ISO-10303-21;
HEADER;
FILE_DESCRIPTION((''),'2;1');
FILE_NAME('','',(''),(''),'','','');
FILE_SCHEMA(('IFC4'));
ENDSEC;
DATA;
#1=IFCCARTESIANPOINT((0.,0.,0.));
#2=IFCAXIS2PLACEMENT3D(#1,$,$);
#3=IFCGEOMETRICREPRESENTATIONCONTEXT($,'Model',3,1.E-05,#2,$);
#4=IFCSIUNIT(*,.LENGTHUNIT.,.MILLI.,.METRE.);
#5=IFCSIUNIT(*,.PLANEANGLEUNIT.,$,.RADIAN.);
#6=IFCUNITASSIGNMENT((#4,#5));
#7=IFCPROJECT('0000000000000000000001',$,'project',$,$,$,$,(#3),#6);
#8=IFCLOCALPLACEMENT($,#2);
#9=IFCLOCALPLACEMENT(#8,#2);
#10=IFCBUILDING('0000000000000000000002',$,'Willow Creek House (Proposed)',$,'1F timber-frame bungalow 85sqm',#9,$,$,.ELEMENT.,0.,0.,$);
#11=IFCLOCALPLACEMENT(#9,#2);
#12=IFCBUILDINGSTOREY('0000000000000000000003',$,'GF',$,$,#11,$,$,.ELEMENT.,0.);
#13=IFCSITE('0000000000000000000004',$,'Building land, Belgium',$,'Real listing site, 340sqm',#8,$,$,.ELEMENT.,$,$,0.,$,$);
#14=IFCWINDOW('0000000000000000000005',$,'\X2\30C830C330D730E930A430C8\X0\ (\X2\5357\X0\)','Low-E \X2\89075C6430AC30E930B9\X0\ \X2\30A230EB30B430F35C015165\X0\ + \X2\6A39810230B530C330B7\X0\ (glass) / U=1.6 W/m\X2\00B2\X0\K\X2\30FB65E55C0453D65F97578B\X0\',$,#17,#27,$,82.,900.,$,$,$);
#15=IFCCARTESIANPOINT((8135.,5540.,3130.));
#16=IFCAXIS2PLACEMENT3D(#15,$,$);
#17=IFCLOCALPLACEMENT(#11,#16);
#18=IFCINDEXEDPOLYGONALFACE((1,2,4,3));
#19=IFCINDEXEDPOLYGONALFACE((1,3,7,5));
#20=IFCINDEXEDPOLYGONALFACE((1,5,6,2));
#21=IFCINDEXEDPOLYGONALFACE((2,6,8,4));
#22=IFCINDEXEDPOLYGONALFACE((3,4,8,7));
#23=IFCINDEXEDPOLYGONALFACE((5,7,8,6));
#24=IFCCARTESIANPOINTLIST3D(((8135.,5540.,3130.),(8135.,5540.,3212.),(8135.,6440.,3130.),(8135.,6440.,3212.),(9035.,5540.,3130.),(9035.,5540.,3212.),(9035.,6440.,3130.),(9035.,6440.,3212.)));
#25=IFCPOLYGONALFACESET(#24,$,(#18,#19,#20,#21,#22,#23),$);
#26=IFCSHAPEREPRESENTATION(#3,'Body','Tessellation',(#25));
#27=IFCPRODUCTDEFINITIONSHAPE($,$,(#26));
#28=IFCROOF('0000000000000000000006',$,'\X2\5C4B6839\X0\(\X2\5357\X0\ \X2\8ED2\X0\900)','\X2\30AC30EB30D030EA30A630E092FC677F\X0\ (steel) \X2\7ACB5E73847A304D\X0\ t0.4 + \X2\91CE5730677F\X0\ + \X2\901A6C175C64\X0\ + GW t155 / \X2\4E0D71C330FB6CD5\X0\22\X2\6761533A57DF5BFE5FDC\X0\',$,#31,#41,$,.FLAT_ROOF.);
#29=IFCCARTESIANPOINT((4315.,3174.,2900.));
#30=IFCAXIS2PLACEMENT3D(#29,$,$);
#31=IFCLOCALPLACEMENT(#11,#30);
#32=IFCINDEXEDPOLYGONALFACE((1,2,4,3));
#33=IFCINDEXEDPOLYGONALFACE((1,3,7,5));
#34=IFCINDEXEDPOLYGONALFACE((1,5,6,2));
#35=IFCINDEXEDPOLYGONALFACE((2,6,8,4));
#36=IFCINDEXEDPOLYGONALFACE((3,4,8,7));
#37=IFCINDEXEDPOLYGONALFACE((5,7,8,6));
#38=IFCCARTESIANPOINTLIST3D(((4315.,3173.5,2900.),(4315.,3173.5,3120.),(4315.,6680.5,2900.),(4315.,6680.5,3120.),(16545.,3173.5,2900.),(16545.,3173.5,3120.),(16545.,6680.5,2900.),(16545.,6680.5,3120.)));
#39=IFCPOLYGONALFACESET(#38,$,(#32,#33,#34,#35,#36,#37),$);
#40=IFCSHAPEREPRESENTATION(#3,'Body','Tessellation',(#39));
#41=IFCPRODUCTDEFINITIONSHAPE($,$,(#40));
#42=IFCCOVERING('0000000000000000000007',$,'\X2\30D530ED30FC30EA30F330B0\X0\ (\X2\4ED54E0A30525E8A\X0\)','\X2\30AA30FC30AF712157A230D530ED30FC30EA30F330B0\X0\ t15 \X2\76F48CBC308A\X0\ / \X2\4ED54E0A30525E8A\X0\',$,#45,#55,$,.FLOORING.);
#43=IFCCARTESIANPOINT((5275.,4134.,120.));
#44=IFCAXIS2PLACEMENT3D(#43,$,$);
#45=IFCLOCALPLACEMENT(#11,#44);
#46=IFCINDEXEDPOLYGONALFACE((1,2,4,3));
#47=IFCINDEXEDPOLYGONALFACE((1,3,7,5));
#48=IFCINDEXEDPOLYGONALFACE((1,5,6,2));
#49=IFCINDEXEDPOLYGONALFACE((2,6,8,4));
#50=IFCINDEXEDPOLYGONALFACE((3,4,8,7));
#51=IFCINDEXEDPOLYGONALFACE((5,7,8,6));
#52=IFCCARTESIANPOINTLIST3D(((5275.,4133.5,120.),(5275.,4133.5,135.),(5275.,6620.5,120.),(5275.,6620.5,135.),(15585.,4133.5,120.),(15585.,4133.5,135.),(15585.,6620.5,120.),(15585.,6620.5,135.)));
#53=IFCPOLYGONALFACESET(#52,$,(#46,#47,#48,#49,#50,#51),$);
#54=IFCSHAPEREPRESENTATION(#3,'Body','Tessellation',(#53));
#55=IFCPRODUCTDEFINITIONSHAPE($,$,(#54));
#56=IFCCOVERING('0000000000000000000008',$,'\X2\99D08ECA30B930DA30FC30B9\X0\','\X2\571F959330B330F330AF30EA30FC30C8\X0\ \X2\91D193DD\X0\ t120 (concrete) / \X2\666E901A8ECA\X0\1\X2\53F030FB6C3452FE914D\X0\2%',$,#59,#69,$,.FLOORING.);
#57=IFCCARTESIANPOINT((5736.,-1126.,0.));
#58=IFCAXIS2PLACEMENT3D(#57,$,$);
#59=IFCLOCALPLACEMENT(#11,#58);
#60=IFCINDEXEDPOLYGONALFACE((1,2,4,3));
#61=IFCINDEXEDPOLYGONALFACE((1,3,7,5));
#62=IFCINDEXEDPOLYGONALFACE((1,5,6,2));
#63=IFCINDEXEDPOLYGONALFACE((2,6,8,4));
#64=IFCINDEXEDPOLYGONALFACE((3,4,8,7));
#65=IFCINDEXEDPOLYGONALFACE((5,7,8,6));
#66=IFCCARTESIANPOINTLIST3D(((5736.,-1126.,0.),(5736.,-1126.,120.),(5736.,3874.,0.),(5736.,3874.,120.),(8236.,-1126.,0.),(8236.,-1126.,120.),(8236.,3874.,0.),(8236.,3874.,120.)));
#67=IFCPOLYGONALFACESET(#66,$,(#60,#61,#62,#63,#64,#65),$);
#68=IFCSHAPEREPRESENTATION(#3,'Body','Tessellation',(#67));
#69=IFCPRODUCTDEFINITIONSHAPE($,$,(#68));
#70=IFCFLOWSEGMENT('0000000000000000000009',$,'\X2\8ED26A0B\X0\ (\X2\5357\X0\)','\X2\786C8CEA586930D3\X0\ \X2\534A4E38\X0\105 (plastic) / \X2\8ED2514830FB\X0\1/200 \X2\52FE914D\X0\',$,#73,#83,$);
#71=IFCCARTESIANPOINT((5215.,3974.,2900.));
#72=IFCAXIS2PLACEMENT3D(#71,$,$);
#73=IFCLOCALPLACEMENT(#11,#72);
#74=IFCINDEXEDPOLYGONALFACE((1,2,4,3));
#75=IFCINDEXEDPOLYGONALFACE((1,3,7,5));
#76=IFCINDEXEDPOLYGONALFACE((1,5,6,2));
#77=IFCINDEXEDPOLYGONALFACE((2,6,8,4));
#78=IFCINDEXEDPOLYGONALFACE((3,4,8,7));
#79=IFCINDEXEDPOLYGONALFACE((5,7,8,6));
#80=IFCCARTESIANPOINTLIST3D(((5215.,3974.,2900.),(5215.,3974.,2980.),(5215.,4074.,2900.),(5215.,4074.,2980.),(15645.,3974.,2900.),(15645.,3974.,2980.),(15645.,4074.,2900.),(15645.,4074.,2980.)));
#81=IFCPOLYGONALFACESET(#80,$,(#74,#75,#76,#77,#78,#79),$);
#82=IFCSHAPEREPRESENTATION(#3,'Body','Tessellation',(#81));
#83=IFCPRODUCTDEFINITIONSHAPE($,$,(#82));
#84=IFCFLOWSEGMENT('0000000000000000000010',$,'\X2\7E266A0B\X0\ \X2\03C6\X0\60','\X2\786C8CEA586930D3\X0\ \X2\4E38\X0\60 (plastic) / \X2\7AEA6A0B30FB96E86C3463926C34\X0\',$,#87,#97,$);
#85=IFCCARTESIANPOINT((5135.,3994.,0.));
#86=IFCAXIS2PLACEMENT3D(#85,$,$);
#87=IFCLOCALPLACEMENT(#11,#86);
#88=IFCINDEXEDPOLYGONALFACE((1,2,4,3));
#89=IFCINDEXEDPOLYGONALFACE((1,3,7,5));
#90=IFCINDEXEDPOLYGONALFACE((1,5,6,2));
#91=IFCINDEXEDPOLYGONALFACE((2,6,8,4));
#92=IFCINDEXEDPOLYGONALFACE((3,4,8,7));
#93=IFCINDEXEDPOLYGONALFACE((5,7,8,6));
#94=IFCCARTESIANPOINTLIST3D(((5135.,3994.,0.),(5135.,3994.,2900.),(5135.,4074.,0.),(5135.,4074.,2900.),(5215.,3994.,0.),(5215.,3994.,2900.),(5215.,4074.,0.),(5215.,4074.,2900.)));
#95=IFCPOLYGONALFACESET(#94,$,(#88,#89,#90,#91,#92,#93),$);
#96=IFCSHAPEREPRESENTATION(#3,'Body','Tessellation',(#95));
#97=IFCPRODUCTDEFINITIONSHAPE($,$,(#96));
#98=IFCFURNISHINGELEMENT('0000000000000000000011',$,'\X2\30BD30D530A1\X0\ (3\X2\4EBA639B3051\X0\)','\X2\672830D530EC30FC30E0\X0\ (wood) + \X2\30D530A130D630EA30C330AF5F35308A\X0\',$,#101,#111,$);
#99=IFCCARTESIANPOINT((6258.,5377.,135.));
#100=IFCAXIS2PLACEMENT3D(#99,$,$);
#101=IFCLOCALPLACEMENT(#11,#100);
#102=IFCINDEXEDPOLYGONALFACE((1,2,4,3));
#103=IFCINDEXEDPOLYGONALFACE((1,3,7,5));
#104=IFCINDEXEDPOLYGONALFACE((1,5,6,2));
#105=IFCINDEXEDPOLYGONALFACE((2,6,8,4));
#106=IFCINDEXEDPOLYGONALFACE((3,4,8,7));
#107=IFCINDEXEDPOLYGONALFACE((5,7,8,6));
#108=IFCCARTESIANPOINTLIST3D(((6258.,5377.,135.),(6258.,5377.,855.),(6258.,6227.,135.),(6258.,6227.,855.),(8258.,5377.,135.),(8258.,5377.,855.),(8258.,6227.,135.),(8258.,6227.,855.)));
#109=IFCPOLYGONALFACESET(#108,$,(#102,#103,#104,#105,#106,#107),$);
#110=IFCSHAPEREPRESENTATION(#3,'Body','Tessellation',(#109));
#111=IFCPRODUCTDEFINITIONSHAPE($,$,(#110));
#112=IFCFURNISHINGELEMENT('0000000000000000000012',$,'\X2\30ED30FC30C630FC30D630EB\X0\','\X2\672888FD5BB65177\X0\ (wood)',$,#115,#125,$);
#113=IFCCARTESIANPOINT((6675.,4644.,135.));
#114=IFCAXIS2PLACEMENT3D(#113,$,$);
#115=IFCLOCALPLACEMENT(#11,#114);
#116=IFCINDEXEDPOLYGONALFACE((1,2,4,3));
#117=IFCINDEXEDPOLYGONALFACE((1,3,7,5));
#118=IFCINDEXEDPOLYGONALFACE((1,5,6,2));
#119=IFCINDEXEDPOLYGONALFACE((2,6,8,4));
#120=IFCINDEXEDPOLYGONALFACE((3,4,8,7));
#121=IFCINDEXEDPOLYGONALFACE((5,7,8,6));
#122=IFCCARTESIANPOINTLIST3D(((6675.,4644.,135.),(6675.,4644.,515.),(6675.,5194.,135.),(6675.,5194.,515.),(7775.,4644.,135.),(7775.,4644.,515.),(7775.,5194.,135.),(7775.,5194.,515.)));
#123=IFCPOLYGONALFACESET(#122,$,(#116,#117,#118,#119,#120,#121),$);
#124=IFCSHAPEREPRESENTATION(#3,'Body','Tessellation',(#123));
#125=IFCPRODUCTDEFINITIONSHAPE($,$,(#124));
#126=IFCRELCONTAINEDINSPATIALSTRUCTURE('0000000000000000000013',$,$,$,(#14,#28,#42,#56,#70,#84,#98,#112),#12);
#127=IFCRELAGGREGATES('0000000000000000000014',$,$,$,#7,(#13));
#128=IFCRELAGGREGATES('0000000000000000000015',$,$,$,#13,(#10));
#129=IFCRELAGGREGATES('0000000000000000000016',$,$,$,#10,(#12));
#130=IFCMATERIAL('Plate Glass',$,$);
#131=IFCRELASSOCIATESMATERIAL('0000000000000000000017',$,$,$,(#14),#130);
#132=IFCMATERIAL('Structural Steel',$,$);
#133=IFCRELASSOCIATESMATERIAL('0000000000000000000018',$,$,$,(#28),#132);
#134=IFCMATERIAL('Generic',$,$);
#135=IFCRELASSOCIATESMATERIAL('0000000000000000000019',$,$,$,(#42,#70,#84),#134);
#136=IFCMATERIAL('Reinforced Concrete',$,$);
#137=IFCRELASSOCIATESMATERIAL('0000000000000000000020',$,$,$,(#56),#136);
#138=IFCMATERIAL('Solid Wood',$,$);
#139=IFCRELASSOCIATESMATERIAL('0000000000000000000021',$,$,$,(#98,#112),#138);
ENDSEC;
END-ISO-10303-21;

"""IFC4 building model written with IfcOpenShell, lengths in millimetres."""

from ifc_helpers import new_model, si_unit, frame, frame_2d, origin, place, context, project, spatial, rectangle, extrude, material, element, save


model = new_model("IFC4")

# Units and contexts
model_context = context("Model", 3, precision=1e-05, world=origin())
ifc_project = project(units=[si_unit("LENGTHUNIT", "METRE", prefix="MILLI"), si_unit("PLANEANGLEUNIT", "RADIAN")], contexts=[model_context])

# Site, building, storey
site_placement = place(None, origin())
site = spatial("IfcSite", under=ifc_project, at=site_placement, Name="Building land, Belgium", ObjectType="Real listing site, 340sqm", CompositionType="ELEMENT", RefElevation=0.0)
building_placement = place(site_placement, origin())
building = spatial("IfcBuilding", under=site, at=building_placement, Name="Willow Creek House (Proposed)", ObjectType="1F timber-frame bungalow 85sqm", CompositionType="ELEMENT", ElevationOfRefHeight=0.0, ElevationOfTerrain=0.0)
storey_placement = place(building_placement, origin())
storey = spatial("IfcBuildingStorey", under=building, at=storey_placement, Name="GF", CompositionType="ELEMENT", Elevation=0.0)

# Shared definitions
ifc_material_1 = material(Name="Solid Wood")

# Shared definitions
ifc_material_2 = material(Name="Reinforced Concrete")

# Shared definitions
ifc_material_3 = material(Name="Plate Glass")

# Window
window_1_placement = place(storey_placement, frame((8135.0, 5540.0, 3130.0)))
element("IfcWindow", 1, at=window_1_placement, inside=storey, material=ifc_material_3, Name="トップライト (南)", Description="Low-E 複層ガラス アルゴン封入 + 樹脂サッシ (glass) / U=1.6 W/m²K・日射取得型", OverallHeight=82.0, OverallWidth=900.0, context=model_context, shape_type="SweptSolid", body=[
    extrude(rectangle(XDim=900.0, YDim=900.0, at=frame_2d((450.0, 450.0))), frame((8135.0, 5540.0, 3130.0)), (0.0, 0.0, 1.0), 82.0),
])

# Roof
ifc_material_4 = material(Name="Structural Steel")
roof_1_placement = place(storey_placement, frame((4315.0, 3174.0, 2900.0)))
element("IfcRoof", 2, at=roof_1_placement, inside=storey, material=ifc_material_4, Name="屋根(南 軒900)", Description="ガルバリウム鋼板 (steel) 立平葺き t0.4 + 野地板 + 通気層 + GW t155 / 不燃・法22条区域対応", PredefinedType="FLAT_ROOF", context=model_context, shape_type="SweptSolid", body=[
    extrude(rectangle(XDim=12230.0, YDim=3507.0, at=frame_2d((6115.0, 1753.0))), frame((4315.0, 3174.0, 2900.0)), (0.0, 0.0, 1.0), 220.0),
])

# Coverings
ifc_material_5 = material(Name="Generic")
covering_1_placement = place(storey_placement, frame((5275.0, 4134.0, 120.0)))
element("IfcCovering", 3, at=covering_1_placement, inside=storey, material=ifc_material_5, Name="フローリング (仕上げ床)", Description="オーク無垢フローリング t15 直貼り / 仕上げ床", PredefinedType="FLOORING", context=model_context, shape_type="SweptSolid", body=[
    extrude(rectangle(XDim=10310.0, YDim=2487.0, at=frame_2d((5155.0, 1243.0))), frame((5275.0, 4134.0, 120.0)), (0.0, 0.0, 1.0), 15.0),
])
covering_2_placement = place(storey_placement, frame((5736.0, -1126.0, 0.0)))
element("IfcCovering", 4, at=covering_2_placement, inside=storey, material=ifc_material_2, Name="駐車スペース", Description="土間コンクリート 金鏝 t120 (concrete) / 普通車1台・水勾配2%", PredefinedType="FLOORING", context=model_context, shape_type="SweptSolid", body=[
    extrude(rectangle(XDim=2500.0, YDim=5000.0, at=frame_2d((1250.0, 2500.0))), frame((5736.0, -1126.0, 0.0)), (0.0, 0.0, 1.0), 120.0),
])

# Flow segments
flow_segment_1_placement = place(storey_placement, frame((5215.0, 3974.0, 2900.0)))
element("IfcFlowSegment", 5, at=flow_segment_1_placement, inside=storey, material=ifc_material_5, Name="軒樋 (南)", Description="硬質塩ビ 半丸105 (plastic) / 軒先・1/200 勾配", context=model_context, shape_type="SweptSolid", body=[
    extrude(rectangle(XDim=10430.0, YDim=100.0, at=frame_2d((5215.0, 50.0))), frame((5215.0, 3974.0, 2900.0)), (0.0, 0.0, 1.0), 80.0),
])
flow_segment_2_placement = place(storey_placement, frame((5135.0, 3994.0, 0.0)))
element("IfcFlowSegment", 6, at=flow_segment_2_placement, inside=storey, material=ifc_material_5, Name="縦樋 φ60", Description="硬質塩ビ 丸60 (plastic) / 竪樋・雨水排水", context=model_context, shape_type="SweptSolid", body=[
    extrude(rectangle(XDim=80.0, YDim=80.0, at=frame_2d((40.0, 40.0))), frame((5135.0, 3994.0, 0.0)), (0.0, 0.0, 1.0), 2900.0),
])

# Furnishing elements
furnishing_1_placement = place(storey_placement, frame((6258.0, 5377.0, 135.0)))
element("IfcFurnishingElement", 7, at=furnishing_1_placement, inside=storey, material=ifc_material_1, Name="ソファ (3人掛け)", Description="木フレーム (wood) + ファブリック張り", context=model_context, shape_type="SweptSolid", body=[
    extrude(rectangle(XDim=2000.0, YDim=850.0, at=frame_2d((1000.0, 425.0))), frame((6258.0, 5377.0, 135.0)), (0.0, 0.0, 1.0), 720.0),
])
furnishing_2_placement = place(storey_placement, frame((6675.0, 4644.0, 135.0)))
element("IfcFurnishingElement", 8, at=furnishing_2_placement, inside=storey, material=ifc_material_1, Name="ローテーブル", Description="木製家具 (wood)", context=model_context, shape_type="SweptSolid", body=[
    extrude(rectangle(XDim=1100.0, YDim=550.0, at=frame_2d((550.0, 275.0))), frame((6675.0, 4644.0, 135.0)), (0.0, 0.0, 1.0), 380.0),
])

save(model, "model.ifc")
